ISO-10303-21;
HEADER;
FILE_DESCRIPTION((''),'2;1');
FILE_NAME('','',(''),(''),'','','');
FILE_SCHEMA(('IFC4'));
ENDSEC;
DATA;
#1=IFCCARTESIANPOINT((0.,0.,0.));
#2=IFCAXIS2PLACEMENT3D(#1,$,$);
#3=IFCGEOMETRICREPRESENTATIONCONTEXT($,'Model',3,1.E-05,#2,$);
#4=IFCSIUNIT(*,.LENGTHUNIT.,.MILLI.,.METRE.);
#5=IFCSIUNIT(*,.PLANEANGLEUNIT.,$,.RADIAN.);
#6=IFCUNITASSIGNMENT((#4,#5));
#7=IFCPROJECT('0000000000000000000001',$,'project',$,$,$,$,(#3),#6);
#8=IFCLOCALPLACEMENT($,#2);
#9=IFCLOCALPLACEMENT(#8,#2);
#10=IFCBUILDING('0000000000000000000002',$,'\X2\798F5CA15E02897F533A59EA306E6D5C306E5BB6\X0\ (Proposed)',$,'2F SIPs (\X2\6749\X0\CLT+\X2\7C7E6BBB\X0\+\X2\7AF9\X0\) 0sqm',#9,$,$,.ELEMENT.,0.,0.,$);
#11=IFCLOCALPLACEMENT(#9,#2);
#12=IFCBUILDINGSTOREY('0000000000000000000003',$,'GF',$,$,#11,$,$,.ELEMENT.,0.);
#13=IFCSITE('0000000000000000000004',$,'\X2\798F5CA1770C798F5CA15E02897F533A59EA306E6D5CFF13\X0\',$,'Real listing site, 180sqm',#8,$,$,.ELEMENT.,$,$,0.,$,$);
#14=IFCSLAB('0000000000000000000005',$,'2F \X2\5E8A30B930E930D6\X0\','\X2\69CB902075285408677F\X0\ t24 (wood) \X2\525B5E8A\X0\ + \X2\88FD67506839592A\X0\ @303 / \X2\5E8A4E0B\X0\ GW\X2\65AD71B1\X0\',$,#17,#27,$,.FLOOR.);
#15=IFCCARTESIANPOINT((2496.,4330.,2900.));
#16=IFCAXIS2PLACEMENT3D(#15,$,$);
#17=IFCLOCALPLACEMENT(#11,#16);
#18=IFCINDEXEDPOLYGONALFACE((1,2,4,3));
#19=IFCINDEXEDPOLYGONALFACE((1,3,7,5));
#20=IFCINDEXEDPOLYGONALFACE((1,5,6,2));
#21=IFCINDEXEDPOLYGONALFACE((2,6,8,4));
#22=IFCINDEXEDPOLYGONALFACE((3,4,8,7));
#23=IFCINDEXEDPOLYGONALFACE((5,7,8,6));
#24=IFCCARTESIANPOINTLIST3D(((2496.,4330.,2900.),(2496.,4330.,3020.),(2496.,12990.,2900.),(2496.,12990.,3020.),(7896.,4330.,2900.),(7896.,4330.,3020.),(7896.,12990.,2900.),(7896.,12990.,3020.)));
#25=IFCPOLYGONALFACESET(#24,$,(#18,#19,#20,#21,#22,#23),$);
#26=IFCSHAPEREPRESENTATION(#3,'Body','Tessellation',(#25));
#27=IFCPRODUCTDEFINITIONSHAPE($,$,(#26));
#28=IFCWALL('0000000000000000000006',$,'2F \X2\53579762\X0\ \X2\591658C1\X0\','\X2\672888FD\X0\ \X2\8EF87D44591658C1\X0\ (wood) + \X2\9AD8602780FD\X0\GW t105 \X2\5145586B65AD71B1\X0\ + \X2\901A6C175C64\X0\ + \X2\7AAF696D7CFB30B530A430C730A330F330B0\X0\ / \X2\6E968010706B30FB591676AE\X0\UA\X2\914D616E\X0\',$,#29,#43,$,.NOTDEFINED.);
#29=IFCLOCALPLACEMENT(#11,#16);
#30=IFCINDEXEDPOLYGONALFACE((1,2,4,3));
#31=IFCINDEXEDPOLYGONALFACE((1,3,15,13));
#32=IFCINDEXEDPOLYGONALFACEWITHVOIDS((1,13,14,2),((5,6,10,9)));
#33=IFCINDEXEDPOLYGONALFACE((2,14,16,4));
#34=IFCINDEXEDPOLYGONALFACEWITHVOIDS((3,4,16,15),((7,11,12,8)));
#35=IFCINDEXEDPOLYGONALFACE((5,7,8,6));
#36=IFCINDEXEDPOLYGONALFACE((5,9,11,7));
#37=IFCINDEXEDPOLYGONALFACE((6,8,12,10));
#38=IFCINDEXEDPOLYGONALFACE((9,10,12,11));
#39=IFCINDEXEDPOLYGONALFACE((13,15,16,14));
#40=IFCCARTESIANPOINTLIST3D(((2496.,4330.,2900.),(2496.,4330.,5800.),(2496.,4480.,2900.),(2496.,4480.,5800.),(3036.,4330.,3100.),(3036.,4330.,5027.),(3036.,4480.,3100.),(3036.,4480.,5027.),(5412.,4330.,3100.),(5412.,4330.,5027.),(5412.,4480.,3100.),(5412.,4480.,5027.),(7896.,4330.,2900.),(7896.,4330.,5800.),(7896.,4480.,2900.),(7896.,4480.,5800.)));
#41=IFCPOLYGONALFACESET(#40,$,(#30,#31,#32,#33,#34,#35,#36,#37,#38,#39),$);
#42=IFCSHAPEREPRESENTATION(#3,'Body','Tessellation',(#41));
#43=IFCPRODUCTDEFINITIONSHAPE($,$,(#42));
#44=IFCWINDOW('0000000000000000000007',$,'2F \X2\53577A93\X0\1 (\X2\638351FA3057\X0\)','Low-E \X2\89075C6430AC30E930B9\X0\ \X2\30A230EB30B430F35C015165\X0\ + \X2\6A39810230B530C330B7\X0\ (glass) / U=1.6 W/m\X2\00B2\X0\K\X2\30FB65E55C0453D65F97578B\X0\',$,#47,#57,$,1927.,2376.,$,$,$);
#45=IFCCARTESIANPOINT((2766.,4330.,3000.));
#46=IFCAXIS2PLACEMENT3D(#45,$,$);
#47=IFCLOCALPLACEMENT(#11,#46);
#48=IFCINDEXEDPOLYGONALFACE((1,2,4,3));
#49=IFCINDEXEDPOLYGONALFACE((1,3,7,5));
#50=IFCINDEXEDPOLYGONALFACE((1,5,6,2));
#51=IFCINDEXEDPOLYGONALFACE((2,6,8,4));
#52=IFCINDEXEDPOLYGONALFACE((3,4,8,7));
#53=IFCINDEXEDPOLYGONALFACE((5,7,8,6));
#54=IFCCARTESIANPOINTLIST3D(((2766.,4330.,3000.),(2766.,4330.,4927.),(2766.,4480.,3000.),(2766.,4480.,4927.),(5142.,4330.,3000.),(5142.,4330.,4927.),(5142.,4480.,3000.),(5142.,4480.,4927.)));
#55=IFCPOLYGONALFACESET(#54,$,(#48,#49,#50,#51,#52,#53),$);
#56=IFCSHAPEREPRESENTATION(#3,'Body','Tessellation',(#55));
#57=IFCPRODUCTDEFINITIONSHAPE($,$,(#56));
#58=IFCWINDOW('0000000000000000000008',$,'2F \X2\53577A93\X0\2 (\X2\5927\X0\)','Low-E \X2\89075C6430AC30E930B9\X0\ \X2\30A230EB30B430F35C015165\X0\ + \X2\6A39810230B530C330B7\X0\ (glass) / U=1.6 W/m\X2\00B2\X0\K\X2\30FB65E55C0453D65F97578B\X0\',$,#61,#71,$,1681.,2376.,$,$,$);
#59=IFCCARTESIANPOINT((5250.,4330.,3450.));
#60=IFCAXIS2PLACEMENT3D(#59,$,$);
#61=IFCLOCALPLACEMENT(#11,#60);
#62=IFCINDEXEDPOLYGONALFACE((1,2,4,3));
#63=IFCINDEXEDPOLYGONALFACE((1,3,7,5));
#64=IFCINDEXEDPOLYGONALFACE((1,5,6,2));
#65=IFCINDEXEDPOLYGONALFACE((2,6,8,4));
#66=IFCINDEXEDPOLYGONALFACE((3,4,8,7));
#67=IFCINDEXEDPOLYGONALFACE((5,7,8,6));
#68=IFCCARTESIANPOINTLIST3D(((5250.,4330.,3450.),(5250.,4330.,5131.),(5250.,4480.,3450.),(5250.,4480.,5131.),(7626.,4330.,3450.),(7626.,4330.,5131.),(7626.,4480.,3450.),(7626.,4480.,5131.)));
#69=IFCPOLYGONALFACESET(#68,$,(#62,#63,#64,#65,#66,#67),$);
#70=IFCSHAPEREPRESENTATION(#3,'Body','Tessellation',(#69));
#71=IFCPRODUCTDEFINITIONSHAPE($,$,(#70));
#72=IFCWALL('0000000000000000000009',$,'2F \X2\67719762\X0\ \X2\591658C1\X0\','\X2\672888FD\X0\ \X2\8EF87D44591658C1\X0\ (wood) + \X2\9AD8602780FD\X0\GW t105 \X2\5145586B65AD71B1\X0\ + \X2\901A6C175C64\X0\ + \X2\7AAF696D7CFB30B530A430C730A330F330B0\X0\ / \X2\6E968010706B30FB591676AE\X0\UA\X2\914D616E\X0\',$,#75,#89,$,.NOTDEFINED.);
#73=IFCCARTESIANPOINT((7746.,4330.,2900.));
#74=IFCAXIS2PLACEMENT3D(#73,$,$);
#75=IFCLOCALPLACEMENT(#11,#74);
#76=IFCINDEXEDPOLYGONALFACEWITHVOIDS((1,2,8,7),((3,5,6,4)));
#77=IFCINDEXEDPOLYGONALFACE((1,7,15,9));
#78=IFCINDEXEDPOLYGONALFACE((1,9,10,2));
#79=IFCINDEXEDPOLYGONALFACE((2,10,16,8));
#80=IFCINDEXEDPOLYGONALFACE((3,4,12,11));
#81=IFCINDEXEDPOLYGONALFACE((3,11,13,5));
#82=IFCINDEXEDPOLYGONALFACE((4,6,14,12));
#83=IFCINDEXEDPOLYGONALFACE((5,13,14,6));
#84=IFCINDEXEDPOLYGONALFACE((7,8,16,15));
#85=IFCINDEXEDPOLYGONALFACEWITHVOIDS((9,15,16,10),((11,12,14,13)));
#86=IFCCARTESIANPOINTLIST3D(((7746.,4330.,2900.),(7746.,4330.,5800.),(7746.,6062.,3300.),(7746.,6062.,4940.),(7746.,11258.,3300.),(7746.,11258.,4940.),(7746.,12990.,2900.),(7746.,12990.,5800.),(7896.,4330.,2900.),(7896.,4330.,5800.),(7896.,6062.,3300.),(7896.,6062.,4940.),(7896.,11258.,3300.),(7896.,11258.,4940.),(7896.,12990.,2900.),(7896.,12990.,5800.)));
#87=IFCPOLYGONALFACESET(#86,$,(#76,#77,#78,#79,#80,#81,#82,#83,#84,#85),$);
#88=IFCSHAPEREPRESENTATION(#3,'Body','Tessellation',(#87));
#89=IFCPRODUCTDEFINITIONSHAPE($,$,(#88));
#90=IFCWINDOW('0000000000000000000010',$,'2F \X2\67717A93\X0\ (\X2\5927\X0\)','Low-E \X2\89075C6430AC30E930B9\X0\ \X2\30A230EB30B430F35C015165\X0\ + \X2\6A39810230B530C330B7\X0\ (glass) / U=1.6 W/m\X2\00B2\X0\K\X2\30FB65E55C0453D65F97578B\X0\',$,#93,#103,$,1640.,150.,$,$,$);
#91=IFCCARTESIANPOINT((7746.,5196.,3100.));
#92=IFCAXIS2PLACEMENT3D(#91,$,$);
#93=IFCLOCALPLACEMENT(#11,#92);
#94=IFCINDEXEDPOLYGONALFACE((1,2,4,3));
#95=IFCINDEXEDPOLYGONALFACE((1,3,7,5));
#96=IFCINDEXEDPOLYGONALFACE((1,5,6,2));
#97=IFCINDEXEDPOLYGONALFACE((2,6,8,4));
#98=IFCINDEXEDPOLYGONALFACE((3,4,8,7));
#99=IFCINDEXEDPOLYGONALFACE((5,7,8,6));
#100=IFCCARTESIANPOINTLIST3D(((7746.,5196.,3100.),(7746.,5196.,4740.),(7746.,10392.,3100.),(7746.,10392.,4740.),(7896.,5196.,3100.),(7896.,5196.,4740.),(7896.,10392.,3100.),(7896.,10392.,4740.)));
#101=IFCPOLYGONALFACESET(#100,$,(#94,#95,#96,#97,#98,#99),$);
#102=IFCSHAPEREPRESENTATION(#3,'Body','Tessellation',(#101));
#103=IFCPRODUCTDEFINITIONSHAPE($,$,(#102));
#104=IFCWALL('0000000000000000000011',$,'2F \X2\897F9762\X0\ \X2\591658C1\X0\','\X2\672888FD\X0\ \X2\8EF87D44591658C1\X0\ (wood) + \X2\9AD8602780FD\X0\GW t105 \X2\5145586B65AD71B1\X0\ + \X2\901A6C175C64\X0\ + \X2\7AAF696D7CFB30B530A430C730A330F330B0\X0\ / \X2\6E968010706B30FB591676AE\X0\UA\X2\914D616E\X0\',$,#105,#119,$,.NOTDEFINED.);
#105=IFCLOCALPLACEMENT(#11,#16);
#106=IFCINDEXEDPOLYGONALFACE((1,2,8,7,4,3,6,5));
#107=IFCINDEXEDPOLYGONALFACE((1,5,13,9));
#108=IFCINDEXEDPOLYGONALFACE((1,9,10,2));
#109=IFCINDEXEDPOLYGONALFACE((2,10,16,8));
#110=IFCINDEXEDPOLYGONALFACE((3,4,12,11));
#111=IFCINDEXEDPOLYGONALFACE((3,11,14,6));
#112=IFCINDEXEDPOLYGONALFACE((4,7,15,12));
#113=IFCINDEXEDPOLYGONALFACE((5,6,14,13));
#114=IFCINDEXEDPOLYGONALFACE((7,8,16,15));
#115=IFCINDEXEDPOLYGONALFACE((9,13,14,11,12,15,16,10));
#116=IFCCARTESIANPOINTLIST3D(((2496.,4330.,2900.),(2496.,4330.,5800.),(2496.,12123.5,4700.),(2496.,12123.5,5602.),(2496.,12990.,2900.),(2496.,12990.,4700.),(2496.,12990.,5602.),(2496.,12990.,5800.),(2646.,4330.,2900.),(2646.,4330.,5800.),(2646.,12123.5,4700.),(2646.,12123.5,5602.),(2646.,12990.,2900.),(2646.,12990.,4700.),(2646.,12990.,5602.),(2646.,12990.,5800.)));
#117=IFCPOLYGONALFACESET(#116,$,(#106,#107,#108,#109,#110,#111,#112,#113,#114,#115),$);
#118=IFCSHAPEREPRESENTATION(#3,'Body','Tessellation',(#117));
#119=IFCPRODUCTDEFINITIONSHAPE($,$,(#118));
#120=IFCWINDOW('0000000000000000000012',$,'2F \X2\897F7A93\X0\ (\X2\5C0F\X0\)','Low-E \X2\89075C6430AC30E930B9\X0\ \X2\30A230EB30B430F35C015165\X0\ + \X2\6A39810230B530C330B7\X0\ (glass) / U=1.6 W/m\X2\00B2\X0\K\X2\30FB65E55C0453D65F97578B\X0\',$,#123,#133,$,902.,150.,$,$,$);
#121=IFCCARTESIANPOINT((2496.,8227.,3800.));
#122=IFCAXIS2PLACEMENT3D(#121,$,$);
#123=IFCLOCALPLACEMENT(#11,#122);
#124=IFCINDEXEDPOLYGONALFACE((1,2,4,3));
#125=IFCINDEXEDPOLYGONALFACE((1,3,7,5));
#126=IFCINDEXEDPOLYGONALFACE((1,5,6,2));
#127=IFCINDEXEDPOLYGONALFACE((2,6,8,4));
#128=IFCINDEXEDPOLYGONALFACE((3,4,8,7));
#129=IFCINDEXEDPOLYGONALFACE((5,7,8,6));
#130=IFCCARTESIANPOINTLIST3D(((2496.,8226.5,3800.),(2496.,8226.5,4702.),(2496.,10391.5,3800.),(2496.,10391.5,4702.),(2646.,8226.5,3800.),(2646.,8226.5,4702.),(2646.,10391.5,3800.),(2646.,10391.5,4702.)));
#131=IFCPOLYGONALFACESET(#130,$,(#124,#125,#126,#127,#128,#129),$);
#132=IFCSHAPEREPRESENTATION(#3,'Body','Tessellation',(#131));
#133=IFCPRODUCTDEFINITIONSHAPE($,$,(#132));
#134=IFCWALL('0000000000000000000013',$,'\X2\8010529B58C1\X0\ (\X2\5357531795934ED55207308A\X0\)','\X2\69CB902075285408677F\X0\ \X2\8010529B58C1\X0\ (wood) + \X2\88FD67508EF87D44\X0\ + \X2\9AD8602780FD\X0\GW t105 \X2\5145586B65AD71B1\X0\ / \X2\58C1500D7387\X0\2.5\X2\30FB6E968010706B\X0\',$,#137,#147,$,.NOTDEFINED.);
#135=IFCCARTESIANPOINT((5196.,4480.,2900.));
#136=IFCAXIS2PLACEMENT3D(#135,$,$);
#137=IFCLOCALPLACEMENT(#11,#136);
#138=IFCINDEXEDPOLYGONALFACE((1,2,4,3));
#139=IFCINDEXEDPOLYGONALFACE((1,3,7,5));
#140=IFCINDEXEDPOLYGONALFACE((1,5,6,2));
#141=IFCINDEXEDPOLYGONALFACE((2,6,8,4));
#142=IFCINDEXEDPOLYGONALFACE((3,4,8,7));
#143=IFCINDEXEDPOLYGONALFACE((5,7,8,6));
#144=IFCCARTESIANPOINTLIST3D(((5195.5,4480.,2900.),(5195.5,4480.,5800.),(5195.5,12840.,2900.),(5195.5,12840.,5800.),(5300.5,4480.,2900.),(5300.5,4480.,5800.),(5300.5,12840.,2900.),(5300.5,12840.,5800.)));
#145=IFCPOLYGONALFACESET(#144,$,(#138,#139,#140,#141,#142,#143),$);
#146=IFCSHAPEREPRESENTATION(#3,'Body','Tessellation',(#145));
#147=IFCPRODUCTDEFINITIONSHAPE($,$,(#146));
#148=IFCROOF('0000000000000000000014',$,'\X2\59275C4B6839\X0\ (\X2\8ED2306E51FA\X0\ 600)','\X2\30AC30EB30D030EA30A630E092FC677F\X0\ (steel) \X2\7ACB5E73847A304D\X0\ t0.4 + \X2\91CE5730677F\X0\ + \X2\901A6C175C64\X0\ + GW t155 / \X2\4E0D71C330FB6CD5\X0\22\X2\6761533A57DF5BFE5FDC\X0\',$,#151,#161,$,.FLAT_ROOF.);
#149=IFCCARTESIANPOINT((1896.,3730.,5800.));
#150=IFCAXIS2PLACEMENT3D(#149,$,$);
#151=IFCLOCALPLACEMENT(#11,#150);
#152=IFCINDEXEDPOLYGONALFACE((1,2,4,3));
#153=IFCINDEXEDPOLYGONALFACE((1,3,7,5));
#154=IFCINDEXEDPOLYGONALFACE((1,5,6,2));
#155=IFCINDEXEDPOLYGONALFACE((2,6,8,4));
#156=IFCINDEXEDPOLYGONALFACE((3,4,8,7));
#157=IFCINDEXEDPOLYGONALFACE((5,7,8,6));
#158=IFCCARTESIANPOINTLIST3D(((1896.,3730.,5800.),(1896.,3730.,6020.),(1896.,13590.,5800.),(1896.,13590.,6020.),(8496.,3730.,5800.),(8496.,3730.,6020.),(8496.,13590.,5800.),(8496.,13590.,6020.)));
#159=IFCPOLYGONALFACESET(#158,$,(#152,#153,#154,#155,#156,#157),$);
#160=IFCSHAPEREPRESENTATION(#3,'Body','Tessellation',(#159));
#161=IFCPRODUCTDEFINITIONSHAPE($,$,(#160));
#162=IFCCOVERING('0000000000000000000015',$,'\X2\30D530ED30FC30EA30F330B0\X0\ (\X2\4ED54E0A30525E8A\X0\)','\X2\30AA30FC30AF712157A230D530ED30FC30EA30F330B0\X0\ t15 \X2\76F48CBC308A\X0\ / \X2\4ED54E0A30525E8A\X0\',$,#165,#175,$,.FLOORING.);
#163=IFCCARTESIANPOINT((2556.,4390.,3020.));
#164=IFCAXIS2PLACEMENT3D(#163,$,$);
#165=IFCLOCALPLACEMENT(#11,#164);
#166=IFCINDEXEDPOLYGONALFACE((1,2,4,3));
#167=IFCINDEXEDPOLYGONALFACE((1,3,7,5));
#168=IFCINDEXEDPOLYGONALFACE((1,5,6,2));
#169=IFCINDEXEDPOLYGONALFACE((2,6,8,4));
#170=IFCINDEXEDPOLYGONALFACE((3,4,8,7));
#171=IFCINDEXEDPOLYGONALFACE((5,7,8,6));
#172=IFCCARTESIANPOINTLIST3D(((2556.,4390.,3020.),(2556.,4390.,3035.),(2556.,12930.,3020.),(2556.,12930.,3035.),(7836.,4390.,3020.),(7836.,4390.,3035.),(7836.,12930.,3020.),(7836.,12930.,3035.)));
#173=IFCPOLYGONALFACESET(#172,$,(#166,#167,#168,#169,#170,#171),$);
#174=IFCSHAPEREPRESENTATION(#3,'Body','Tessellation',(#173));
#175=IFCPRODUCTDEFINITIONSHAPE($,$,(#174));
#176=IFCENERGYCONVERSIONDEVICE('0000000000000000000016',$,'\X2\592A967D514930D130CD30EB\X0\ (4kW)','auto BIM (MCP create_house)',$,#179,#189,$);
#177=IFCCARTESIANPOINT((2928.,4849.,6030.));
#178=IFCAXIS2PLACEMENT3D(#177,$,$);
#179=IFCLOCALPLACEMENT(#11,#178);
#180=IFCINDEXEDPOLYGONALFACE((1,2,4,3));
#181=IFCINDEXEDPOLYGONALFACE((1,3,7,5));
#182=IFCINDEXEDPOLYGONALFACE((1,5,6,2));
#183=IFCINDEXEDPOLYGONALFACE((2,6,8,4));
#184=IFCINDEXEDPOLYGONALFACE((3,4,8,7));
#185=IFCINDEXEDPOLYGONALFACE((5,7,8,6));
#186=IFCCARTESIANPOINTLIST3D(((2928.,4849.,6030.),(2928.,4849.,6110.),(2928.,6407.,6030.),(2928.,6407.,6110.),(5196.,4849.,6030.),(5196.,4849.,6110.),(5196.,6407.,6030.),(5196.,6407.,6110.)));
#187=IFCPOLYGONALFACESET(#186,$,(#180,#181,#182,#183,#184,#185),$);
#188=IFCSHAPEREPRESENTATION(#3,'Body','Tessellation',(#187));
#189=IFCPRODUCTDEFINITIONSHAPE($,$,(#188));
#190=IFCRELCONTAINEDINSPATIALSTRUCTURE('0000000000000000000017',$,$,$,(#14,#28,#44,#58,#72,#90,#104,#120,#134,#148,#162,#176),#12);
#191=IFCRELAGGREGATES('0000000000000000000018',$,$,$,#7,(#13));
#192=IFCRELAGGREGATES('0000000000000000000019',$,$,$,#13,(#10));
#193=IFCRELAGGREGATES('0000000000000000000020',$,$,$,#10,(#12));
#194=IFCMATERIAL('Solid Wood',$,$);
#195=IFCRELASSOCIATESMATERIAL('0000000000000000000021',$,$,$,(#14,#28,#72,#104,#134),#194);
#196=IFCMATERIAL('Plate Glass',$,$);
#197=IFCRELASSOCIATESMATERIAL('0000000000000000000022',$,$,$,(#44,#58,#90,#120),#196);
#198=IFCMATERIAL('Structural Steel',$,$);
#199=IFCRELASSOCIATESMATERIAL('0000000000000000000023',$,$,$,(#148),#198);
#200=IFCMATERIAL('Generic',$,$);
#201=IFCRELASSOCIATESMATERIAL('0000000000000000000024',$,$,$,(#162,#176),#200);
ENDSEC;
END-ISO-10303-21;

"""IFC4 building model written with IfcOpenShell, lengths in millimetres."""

from ifc_helpers import new_model, si_unit, frame, frame_2d, origin, place, context, project, spatial, rectangle, extrude, material, element, fill, save


model = new_model("IFC4")

# Units and contexts
model_context = context("Model", 3, precision=1e-05, world=origin())
ifc_project = project(units=[si_unit("LENGTHUNIT", "METRE", prefix="MILLI"), si_unit("PLANEANGLEUNIT", "RADIAN")], contexts=[model_context])

# Site, building, storey
site_placement = place(None, origin())
site = spatial("IfcSite", under=ifc_project, at=site_placement, Name="福岡県福岡市西区姪の浜３", ObjectType="Real listing site, 180sqm", CompositionType="ELEMENT", RefElevation=0.0)
building_placement = place(site_placement, origin())
building = spatial("IfcBuilding", under=site, at=building_placement, Name="福岡市西区姪の浜の家 (Proposed)", ObjectType="2F SIPs (杉CLT+籾殻+竹) 0sqm", CompositionType="ELEMENT", ElevationOfRefHeight=0.0, ElevationOfTerrain=0.0)
storey_placement = place(building_placement, origin())
storey = spatial("IfcBuildingStorey", under=building, at=storey_placement, Name="GF", CompositionType="ELEMENT", Elevation=0.0)

# Slab
ifc_material_1 = material(Name="Solid Wood")
slab_placement = place(storey_placement, frame((2496.0, 4330.0, 2900.0)))
element("IfcSlab", 1, at=slab_placement, inside=storey, material=ifc_material_1, Name="2F 床スラブ", Description="構造用合板 t24 (wood) 剛床 + 製材根太 @303 / 床下 GW断熱", PredefinedType="FLOOR", context=model_context, shape_type="SweptSolid", body=[
    extrude(rectangle(XDim=5400.0, YDim=8660.0, at=frame_2d((2700.0, 4330.0))), frame((2496.0, 4330.0, 2900.0)), (0.0, 0.0, 1.0), 120.0),
])

# Wall, openings, windows
wall_1_placement = place(storey_placement, frame((2496.0, 4330.0, 2900.0)))
wall_1 = element("IfcWall", 2, at=wall_1_placement, inside=storey, material=ifc_material_1, Name="2F 南面 外壁", Description="木製 軸組外壁 (wood) + 高性能GW t105 充填断熱 + 通気層 + 窯業系サイディング / 準耐火・外皮UA配慮", PredefinedType="NOTDEFINED", context=model_context, shape_type="SweptSolid", body=[
    extrude(rectangle(XDim=5400.0, YDim=150.0, at=frame_2d((2700.0, 75.0))), frame((2496.0, 4330.0, 2900.0)), (0.0, 0.0, 1.0), 2900.0),
])
opening_1_placement = place(storey_placement, frame((2766.0, 4330.0, 3000.0)))
opening_1 = element("IfcOpeningElement", 3, at=opening_1_placement, cuts=wall_1, PredefinedType="NOTDEFINED", context=model_context, shape_type="SweptSolid", body=[
    extrude(rectangle(XDim=2376.0, YDim=150.0, at=frame_2d((1188.0, 75.0))), frame((2766.0, 4330.0, 3000.0)), (0.0, 0.0, 1.0), 1927.0),
])
opening_2_placement = place(storey_placement, frame((5250.0, 4330.0, 3450.0)))
opening_2 = element("IfcOpeningElement", 4, at=opening_2_placement, cuts=wall_1, PredefinedType="NOTDEFINED", context=model_context, shape_type="SweptSolid", body=[
    extrude(rectangle(XDim=2376.0, YDim=150.0, at=frame_2d((1188.0, 75.0))), frame((5250.0, 4330.0, 3450.0)), (0.0, 0.0, 1.0), 1681.0),
])
ifc_material_2 = material(Name="Plate Glass")
window_1_placement = place(storey_placement, frame((2766.0, 4330.0, 3000.0)))
window_1 = element("IfcWindow", 5, at=window_1_placement, inside=storey, material=ifc_material_2, Name="2F 南窓1 (掃出し)", Description="Low-E 複層ガラス アルゴン封入 + 樹脂サッシ (glass) / U=1.6 W/m²K・日射取得型", OverallHeight=1927.0, OverallWidth=2376.0, context=model_context, shape_type="SweptSolid", body=[
    extrude(rectangle(XDim=2376.0, YDim=150.0, at=frame_2d((1188.0, 75.0))), frame((2766.0, 4330.0, 3000.0)), (0.0, 0.0, 1.0), 1927.0),
])
fill(opening_1, window_1)
window_2_placement = place(storey_placement, frame((5250.0, 4330.0, 3450.0)))
window_2 = element("IfcWindow", 6, at=window_2_placement, inside=storey, material=ifc_material_2, Name="2F 南窓2 (大)", Description="Low-E 複層ガラス アルゴン封入 + 樹脂サッシ (glass) / U=1.6 W/m²K・日射取得型", OverallHeight=1681.0, OverallWidth=2376.0, context=model_context, shape_type="SweptSolid", body=[
    extrude(rectangle(XDim=2376.0, YDim=150.0, at=frame_2d((1188.0, 75.0))), frame((5250.0, 4330.0, 3450.0)), (0.0, 0.0, 1.0), 1681.0),
])
fill(opening_2, window_2)

# Walls, openings, windows
wall_2_placement = place(storey_placement, frame((7746.0, 4330.0, 2900.0)))
wall_2 = element("IfcWall", 7, at=wall_2_placement, inside=storey, material=ifc_material_1, Name="2F 東面 外壁", Description="木製 軸組外壁 (wood) + 高性能GW t105 充填断熱 + 通気層 + 窯業系サイディング / 準耐火・外皮UA配慮", PredefinedType="NOTDEFINED", context=model_context, shape_type="SweptSolid", body=[
    extrude(rectangle(XDim=150.0, YDim=8660.0, at=frame_2d((75.0, 4330.0))), frame((7746.0, 4330.0, 2900.0)), (0.0, 0.0, 1.0), 2900.0),
])
opening_3_placement = place(storey_placement, frame((7746.0, 5196.0, 3100.0)))
opening_3 = element("IfcOpeningElement", 8, at=opening_3_placement, cuts=wall_2, PredefinedType="NOTDEFINED", context=model_context, shape_type="SweptSolid", body=[
    extrude(rectangle(XDim=150.0, YDim=5196.0, at=frame_2d((75.0, 2598.0))), frame((7746.0, 5196.0, 3100.0)), (0.0, 0.0, 1.0), 1640.0),
])
window_3_placement = place(storey_placement, frame((7746.0, 5196.0, 3100.0)))
window_3 = element("IfcWindow", 9, at=window_3_placement, inside=storey, material=ifc_material_2, Name="2F 東窓 (大)", Description="Low-E 複層ガラス アルゴン封入 + 樹脂サッシ (glass) / U=1.6 W/m²K・日射取得型", OverallHeight=1640.0, OverallWidth=150.0, context=model_context, shape_type="SweptSolid", body=[
    extrude(rectangle(XDim=150.0, YDim=5196.0, at=frame_2d((75.0, 2598.0))), frame((7746.0, 5196.0, 3100.0)), (0.0, 0.0, 1.0), 1640.0),
])
fill(opening_3, window_3)
wall_3_placement = place(storey_placement, frame((2496.0, 4330.0, 2900.0)))
wall_3 = element("IfcWall", 10, at=wall_3_placement, inside=storey, material=ifc_material_1, Name="2F 西面 外壁", Description="木製 軸組外壁 (wood) + 高性能GW t105 充填断熱 + 通気層 + 窯業系サイディング / 準耐火・外皮UA配慮", PredefinedType="NOTDEFINED", context=model_context, shape_type="SweptSolid", body=[
    extrude(rectangle(XDim=150.0, YDim=8660.0, at=frame_2d((75.0, 4330.0))), frame((2496.0, 4330.0, 2900.0)), (0.0, 0.0, 1.0), 2900.0),
])
opening_4_placement = place(storey_placement, frame((2496.0, 8227.0, 3800.0)))
opening_4 = element("IfcOpeningElement", 11, at=opening_4_placement, cuts=wall_3, PredefinedType="NOTDEFINED", context=model_context, shape_type="SweptSolid", body=[
    extrude(rectangle(XDim=150.0, YDim=2165.0, at=frame_2d((75.0, 1082.0))), frame((2496.0, 8227.0, 3800.0)), (0.0, 0.0, 1.0), 902.0),
])
window_4_placement = place(storey_placement, frame((2496.0, 8227.0, 3800.0)))
window_4 = element("IfcWindow", 12, at=window_4_placement, inside=storey, material=ifc_material_2, Name="2F 西窓 (小)", Description="Low-E 複層ガラス アルゴン封入 + 樹脂サッシ (glass) / U=1.6 W/m²K・日射取得型", OverallHeight=902.0, OverallWidth=150.0, context=model_context, shape_type="SweptSolid", body=[
    extrude(rectangle(XDim=150.0, YDim=2165.0, at=frame_2d((75.0, 1082.0))), frame((2496.0, 8227.0, 3800.0)), (0.0, 0.0, 1.0), 902.0),
])
fill(opening_4, window_4)

# Wall
wall_4_placement = place(storey_placement, frame((5196.0, 4480.0, 2900.0)))
element("IfcWall", 13, at=wall_4_placement, inside=storey, material=ifc_material_1, Name="耐力壁 (南北間仕切り)", Description="構造用合板 耐力壁 (wood) + 製材軸組 + 高性能GW t105 充填断熱 / 壁倍率2.5・準耐火", PredefinedType="NOTDEFINED", context=model_context, shape_type="SweptSolid", body=[
    extrude(rectangle(XDim=105.0, YDim=8360.0, at=frame_2d((52.0, 4180.0))), frame((5196.0, 4480.0, 2900.0)), (0.0, 0.0, 1.0), 2900.0),
])

# Roof
ifc_material_3 = material(Name="Structural Steel")
roof_placement = place(storey_placement, frame((1896.0, 3730.0, 5800.0)))
element("IfcRoof", 14, at=roof_placement, inside=storey, material=ifc_material_3, Name="大屋根 (軒の出 600)", Description="ガルバリウム鋼板 (steel) 立平葺き t0.4 + 野地板 + 通気層 + GW t155 / 不燃・法22条区域対応", PredefinedType="FLAT_ROOF", context=model_context, shape_type="SweptSolid", body=[
    extrude(rectangle(XDim=6600.0, YDim=9860.0, at=frame_2d((3300.0, 4930.0))), frame((1896.0, 3730.0, 5800.0)), (0.0, 0.0, 1.0), 220.0),
])

# Covering
ifc_material_4 = material(Name="Generic")
covering_placement = place(storey_placement, frame((2556.0, 4390.0, 3020.0)))
element("IfcCovering", 15, at=covering_placement, inside=storey, material=ifc_material_4, Name="フローリング (仕上げ床)", Description="オーク無垢フローリング t15 直貼り / 仕上げ床", PredefinedType="FLOORING", context=model_context, shape_type="SweptSolid", body=[
    extrude(rectangle(XDim=5280.0, YDim=8540.0, at=frame_2d((2640.0, 4270.0))), frame((2556.0, 4390.0, 3020.0)), (0.0, 0.0, 1.0), 15.0),
])

# Energy conversion device
energy_conversion_device_placement = place(storey_placement, frame((2928.0, 4849.0, 6030.0)))
element("IfcEnergyConversionDevice", 16, at=energy_conversion_device_placement, inside=storey, material=ifc_material_4, Name="太陽光パネル (4kW)", Description="auto BIM (MCP create_house)", context=model_context, shape_type="SweptSolid", body=[
    extrude(rectangle(XDim=2268.0, YDim=1558.0, at=frame_2d((1134.0, 779.0))), frame((2928.0, 4849.0, 6030.0)), (0.0, 0.0, 1.0), 80.0),
])

save(model, "model.ifc")
